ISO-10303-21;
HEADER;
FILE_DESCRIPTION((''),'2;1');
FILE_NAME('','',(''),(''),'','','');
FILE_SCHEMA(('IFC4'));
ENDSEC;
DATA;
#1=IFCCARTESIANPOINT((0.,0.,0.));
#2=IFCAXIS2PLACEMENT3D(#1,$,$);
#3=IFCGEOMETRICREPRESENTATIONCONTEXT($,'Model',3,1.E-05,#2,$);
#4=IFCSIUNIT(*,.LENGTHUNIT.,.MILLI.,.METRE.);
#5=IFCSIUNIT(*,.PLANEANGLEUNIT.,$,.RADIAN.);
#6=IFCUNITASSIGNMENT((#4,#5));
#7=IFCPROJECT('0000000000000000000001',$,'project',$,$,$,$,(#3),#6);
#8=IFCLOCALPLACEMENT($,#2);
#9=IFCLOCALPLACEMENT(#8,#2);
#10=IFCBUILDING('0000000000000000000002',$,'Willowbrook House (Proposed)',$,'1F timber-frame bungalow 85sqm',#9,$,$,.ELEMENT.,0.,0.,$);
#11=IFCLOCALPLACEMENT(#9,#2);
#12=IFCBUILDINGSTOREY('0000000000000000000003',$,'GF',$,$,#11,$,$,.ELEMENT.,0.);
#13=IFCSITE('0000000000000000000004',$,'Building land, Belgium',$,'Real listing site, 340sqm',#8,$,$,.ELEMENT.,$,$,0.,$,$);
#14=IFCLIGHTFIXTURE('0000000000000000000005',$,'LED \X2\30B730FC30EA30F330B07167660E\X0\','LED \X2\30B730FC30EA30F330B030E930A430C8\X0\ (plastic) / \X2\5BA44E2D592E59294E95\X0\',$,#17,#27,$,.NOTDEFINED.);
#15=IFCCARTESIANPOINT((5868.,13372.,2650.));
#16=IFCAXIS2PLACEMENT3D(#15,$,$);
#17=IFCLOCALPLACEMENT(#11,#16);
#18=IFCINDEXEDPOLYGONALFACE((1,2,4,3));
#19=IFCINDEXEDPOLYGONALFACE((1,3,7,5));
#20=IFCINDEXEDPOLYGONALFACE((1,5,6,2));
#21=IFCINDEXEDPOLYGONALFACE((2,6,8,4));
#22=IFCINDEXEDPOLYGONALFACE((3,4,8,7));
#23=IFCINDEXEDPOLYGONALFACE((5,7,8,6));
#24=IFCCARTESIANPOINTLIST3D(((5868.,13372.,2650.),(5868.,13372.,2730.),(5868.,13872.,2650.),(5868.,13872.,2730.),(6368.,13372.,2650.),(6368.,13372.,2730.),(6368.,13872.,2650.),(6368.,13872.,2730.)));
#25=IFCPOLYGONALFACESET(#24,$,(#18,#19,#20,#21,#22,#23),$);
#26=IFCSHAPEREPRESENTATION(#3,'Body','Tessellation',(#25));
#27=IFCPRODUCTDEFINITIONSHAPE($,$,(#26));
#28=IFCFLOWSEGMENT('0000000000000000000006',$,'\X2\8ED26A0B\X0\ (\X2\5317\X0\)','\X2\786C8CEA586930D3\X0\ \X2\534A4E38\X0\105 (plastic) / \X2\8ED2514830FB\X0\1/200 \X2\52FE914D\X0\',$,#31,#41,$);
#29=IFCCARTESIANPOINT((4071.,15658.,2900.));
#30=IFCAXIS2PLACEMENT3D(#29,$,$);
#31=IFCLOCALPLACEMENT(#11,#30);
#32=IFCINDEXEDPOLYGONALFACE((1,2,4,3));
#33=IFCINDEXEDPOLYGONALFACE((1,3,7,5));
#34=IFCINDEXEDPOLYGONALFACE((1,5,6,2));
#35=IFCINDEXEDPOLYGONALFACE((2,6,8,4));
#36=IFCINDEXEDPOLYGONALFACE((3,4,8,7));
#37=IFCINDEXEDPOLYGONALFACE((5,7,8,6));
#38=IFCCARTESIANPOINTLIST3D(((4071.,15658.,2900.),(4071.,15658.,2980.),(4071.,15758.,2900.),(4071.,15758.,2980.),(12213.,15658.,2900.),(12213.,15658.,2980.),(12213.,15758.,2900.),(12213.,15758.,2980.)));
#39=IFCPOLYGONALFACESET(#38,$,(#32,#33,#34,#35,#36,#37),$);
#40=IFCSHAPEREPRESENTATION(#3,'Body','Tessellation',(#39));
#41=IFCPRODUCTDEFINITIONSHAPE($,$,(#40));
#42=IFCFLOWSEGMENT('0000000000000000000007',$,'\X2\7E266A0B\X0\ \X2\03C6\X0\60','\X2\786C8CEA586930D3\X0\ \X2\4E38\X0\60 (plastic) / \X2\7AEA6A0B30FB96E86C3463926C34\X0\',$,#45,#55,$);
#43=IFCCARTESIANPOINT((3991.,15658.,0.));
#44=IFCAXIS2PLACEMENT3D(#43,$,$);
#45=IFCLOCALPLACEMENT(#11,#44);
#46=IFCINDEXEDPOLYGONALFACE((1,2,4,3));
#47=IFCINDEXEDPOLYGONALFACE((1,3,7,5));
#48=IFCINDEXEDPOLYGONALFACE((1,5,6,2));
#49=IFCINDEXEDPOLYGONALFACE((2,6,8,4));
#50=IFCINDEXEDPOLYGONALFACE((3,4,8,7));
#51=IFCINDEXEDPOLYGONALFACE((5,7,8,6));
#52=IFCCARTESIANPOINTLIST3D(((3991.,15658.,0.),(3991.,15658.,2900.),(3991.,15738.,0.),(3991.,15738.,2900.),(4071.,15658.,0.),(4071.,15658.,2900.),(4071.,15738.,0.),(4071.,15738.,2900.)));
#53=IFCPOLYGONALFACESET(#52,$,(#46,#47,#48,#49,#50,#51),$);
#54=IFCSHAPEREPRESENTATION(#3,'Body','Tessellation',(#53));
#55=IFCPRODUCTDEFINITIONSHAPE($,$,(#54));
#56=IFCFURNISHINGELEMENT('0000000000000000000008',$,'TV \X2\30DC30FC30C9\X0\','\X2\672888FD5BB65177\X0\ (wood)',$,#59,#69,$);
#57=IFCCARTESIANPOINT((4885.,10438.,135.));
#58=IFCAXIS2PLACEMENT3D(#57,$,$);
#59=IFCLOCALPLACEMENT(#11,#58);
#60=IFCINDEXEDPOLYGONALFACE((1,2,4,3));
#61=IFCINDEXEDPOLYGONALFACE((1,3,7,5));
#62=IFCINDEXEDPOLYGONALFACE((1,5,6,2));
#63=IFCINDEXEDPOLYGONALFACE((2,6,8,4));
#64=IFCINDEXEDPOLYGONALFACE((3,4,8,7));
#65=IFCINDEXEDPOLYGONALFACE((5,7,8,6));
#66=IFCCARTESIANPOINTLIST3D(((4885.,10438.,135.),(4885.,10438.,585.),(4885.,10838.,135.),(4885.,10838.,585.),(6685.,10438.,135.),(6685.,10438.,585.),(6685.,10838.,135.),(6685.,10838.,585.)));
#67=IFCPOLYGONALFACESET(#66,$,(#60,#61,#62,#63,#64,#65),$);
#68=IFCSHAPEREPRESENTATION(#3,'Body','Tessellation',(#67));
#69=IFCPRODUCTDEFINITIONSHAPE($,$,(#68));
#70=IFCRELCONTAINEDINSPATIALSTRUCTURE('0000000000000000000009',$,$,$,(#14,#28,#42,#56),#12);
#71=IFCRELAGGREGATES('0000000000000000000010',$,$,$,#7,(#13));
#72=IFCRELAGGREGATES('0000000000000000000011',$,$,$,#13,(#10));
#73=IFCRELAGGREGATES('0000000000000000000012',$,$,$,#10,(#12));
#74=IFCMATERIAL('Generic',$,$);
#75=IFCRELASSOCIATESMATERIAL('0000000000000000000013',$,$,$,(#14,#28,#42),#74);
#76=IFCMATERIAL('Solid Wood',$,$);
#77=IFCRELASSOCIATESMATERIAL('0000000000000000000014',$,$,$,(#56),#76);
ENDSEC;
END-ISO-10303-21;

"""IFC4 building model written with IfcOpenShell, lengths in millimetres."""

from ifc_helpers import new_model, si_unit, frame, frame_2d, origin, place, context, project, spatial, rectangle, extrude, material, element, save


model = new_model("IFC4")

# Units and contexts
model_context = context("Model", 3, precision=1e-05, world=origin())
ifc_project = project(units=[si_unit("LENGTHUNIT", "METRE", prefix="MILLI"), si_unit("PLANEANGLEUNIT", "RADIAN")], contexts=[model_context])

# Site, building, storey
site_placement = place(None, origin())
site = spatial("IfcSite", under=ifc_project, at=site_placement, Name="Building land, Belgium", ObjectType="Real listing site, 340sqm", CompositionType="ELEMENT", RefElevation=0.0)
building_placement = place(site_placement, origin())
building = spatial("IfcBuilding", under=site, at=building_placement, Name="Willowbrook House (Proposed)", ObjectType="1F timber-frame bungalow 85sqm", CompositionType="ELEMENT", ElevationOfRefHeight=0.0, ElevationOfTerrain=0.0)
storey_placement = place(building_placement, origin())
storey = spatial("IfcBuildingStorey", under=building, at=storey_placement, Name="GF", CompositionType="ELEMENT", Elevation=0.0)

# Shared definitions
ifc_material_1 = material(Name="Solid Wood")

# Shared definitions
ifc_material_2 = material(Name="Generic")

# Light fixture
light_fixture_placement = place(storey_placement, frame((5868.0, 13372.0, 2650.0)))
element("IfcLightFixture", 1, at=light_fixture_placement, inside=storey, material=ifc_material_2, Name="LED シーリング照明", Description="LED シーリングライト (plastic) / 室中央天井", PredefinedType="NOTDEFINED", context=model_context, shape_type="SweptSolid", body=[
    extrude(rectangle(XDim=500.0, YDim=500.0, at=frame_2d((250.0, 250.0))), frame((5868.0, 13372.0, 2650.0)), (0.0, 0.0, 1.0), 80.0),
])

# Flow segments
flow_segment_1_placement = place(storey_placement, frame((4071.0, 15658.0, 2900.0)))
element("IfcFlowSegment", 2, at=flow_segment_1_placement, inside=storey, material=ifc_material_2, Name="軒樋 (北)", Description="硬質塩ビ 半丸105 (plastic) / 軒先・1/200 勾配", context=model_context, shape_type="SweptSolid", body=[
    extrude(rectangle(XDim=8142.0, YDim=100.0, at=frame_2d((4071.0, 50.0))), frame((4071.0, 15658.0, 2900.0)), (0.0, 0.0, 1.0), 80.0),
])
flow_segment_2_placement = place(storey_placement, frame((3991.0, 15658.0, 0.0)))
element("IfcFlowSegment", 3, at=flow_segment_2_placement, inside=storey, material=ifc_material_2, Name="縦樋 φ60", Description="硬質塩ビ 丸60 (plastic) / 竪樋・雨水排水", context=model_context, shape_type="SweptSolid", body=[
    extrude(rectangle(XDim=80.0, YDim=80.0, at=frame_2d((40.0, 40.0))), frame((3991.0, 15658.0, 0.0)), (0.0, 0.0, 1.0), 2900.0),
])

# Furnishing element
furnishing_placement = place(storey_placement, frame((4885.0, 10438.0, 135.0)))
element("IfcFurnishingElement", 4, at=furnishing_placement, inside=storey, material=ifc_material_1, Name="TV ボード", Description="木製家具 (wood)", context=model_context, shape_type="SweptSolid", body=[
    extrude(rectangle(XDim=1800.0, YDim=400.0, at=frame_2d((900.0, 200.0))), frame((4885.0, 10438.0, 135.0)), (0.0, 0.0, 1.0), 450.0),
])

save(model, "model.ifc")
